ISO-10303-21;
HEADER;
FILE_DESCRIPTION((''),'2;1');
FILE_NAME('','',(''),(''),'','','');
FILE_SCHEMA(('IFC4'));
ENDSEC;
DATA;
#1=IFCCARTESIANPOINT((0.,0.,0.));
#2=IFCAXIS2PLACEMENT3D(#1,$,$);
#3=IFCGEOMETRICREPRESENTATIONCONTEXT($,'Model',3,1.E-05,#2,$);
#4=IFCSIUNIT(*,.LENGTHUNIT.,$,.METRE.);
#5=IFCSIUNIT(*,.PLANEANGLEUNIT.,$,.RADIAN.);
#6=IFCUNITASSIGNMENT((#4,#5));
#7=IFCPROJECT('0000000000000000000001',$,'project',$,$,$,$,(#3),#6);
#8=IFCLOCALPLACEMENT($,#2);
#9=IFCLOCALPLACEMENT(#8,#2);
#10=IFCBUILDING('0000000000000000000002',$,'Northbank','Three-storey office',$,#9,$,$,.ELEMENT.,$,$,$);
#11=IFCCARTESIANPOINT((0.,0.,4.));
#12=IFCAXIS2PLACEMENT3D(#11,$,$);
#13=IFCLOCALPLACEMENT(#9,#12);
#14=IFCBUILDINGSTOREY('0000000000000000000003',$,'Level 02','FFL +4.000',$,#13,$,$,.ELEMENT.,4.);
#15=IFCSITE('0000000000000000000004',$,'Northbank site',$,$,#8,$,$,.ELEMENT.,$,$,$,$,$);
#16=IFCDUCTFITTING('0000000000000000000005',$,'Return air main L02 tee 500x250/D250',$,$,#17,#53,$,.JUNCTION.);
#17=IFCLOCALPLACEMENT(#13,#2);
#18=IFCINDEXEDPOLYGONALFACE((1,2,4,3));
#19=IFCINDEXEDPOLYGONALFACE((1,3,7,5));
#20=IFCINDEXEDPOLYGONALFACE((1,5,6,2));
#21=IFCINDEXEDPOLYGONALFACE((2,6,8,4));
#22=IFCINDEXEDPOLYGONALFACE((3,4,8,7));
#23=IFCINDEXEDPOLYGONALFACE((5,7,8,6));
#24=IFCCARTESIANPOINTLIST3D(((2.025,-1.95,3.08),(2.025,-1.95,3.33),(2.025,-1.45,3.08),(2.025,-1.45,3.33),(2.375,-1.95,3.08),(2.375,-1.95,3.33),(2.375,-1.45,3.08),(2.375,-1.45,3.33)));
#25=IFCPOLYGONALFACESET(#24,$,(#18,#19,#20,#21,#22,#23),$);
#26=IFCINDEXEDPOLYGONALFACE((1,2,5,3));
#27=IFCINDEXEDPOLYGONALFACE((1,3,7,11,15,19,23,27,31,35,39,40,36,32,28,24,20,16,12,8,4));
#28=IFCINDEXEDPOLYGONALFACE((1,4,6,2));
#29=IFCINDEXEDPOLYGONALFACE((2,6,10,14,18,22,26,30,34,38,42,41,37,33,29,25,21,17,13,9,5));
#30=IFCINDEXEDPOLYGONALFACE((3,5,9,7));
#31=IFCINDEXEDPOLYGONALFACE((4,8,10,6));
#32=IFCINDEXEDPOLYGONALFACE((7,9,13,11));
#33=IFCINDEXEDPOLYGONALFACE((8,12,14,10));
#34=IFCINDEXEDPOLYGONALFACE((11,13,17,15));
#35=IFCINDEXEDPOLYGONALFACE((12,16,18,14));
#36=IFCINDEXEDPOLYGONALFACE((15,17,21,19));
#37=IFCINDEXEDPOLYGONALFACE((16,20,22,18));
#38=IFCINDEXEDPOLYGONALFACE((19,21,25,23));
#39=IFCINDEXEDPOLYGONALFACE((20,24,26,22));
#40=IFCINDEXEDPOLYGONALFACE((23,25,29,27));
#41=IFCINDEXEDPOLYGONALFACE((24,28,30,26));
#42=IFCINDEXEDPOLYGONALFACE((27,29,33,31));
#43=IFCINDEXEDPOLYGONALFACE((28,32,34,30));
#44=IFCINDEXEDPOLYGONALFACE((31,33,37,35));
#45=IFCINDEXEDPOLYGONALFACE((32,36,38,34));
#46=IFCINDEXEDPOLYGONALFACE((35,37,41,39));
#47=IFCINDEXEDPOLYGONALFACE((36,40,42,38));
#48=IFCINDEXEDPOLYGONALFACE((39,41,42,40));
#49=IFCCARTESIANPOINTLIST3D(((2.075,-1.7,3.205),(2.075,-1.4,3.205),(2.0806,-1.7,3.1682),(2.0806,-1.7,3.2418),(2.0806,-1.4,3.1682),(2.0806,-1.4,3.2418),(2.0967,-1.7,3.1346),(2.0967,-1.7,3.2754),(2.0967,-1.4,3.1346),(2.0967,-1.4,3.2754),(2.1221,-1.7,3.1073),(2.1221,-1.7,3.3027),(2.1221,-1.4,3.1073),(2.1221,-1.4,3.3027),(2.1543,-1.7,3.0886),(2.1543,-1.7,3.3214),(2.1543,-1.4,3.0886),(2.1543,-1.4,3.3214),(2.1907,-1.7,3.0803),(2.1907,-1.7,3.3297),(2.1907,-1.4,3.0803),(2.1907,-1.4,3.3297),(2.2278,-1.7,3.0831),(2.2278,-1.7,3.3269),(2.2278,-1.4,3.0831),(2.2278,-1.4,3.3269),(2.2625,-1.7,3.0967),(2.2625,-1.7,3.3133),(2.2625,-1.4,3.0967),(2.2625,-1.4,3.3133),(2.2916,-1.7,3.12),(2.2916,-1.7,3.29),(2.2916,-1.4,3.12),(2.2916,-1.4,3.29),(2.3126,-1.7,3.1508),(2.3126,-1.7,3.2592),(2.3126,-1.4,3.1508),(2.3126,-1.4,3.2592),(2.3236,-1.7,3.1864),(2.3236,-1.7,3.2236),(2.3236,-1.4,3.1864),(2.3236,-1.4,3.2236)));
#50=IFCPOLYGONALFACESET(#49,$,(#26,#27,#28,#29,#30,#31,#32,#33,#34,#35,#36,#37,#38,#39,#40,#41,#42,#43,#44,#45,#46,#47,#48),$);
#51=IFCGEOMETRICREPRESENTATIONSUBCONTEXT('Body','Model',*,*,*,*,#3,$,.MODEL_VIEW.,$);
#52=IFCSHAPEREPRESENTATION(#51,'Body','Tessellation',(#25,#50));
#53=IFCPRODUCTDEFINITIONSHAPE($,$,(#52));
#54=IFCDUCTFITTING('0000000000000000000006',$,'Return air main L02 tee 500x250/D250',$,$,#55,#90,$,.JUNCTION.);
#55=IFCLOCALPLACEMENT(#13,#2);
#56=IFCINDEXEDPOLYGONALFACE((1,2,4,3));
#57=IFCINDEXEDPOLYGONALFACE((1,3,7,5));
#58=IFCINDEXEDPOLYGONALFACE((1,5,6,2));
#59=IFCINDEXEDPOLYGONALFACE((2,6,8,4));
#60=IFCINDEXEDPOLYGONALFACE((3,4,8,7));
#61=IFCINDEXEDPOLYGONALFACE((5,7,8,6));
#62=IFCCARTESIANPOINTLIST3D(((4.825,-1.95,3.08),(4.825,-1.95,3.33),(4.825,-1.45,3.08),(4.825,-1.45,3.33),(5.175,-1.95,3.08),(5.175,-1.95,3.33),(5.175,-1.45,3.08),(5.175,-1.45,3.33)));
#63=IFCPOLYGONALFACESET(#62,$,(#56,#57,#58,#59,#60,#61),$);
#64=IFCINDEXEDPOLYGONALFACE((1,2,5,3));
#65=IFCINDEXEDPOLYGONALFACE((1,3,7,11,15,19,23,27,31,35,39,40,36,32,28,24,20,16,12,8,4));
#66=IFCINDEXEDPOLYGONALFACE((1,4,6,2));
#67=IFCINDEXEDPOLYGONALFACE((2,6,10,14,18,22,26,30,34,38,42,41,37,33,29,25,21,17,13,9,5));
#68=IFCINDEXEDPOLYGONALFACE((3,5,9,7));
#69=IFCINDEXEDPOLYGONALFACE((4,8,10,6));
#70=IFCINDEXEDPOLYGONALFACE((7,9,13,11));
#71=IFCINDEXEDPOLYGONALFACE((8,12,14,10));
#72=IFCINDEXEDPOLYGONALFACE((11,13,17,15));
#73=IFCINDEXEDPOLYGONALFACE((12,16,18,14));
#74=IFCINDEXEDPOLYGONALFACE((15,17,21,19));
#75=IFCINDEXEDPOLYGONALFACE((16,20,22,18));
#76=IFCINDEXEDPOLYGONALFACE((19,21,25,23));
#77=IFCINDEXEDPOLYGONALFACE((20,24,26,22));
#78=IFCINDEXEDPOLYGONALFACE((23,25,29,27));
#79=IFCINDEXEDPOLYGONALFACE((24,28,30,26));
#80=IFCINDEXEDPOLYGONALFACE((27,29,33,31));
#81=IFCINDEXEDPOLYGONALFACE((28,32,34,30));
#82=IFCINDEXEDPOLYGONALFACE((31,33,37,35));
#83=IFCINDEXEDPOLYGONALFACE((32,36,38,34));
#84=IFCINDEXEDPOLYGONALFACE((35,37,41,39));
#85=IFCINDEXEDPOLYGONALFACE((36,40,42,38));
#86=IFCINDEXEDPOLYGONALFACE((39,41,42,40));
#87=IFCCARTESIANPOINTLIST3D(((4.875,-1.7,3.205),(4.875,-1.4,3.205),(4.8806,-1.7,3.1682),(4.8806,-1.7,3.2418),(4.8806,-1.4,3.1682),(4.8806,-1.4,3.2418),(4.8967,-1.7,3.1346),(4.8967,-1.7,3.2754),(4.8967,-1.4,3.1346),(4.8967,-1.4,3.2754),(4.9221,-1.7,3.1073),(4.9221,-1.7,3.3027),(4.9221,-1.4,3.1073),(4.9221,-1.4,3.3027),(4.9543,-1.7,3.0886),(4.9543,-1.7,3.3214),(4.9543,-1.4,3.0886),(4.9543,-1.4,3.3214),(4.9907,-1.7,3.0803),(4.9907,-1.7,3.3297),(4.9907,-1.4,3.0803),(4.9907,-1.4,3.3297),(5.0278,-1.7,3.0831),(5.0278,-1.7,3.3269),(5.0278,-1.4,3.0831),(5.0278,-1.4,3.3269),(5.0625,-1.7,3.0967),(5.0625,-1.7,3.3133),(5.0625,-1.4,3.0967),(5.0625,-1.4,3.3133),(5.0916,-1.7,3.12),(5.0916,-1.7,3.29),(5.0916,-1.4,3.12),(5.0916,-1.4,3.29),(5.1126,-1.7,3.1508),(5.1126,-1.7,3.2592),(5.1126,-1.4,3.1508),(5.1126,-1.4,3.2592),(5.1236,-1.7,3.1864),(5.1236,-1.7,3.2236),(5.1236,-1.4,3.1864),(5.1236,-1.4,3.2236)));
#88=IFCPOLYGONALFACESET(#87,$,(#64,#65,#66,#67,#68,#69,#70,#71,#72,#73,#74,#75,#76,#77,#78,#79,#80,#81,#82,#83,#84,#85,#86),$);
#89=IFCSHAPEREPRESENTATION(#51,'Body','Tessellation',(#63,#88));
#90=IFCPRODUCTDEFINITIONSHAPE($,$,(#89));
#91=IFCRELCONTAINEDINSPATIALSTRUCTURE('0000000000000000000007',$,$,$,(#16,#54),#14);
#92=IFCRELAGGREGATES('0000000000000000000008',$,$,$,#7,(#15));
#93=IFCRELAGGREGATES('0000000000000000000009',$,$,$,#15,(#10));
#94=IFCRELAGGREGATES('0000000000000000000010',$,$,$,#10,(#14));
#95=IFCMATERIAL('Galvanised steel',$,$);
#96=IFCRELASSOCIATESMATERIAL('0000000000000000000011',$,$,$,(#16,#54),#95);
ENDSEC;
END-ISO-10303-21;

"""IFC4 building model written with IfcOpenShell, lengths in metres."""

from ifc_helpers import new_model, si_unit, frame, origin, place, context, subcontext, project, spatial, rectangle, circle, extrude, material, element, save


model = new_model("IFC4")

# Units and contexts
model_context = context("Model", 3, precision=1e-05, world=origin())
body_context = subcontext(model_context, "Body", "Model", "MODEL_VIEW")
ifc_project = project(units=[si_unit("LENGTHUNIT", "METRE"), si_unit("PLANEANGLEUNIT", "RADIAN")], contexts=[model_context])

# Site, building, storey
site_placement = place(None, origin())
site = spatial("IfcSite", under=ifc_project, at=site_placement, Name="Northbank site", CompositionType="ELEMENT")
building_placement = place(site_placement, origin())
building = spatial("IfcBuilding", under=site, at=building_placement, Name="Northbank", Description="Three-storey office", CompositionType="ELEMENT")
storey_placement = place(building_placement, frame((0.0, 0.0, 4.0)))
storey = spatial("IfcBuildingStorey", under=building, at=storey_placement, Name="Level 02", Description="FFL +4.000", CompositionType="ELEMENT", Elevation=4.0)

# Shared definitions
ifc_material_1 = material(Name="Galvanised steel")

# Duct fitting
duct_fitting_1_placement = place(storey_placement, frame((0.0, 0.0, -4.0)))
element("IfcDuctFitting", 1, at=duct_fitting_1_placement, inside=storey, material=ifc_material_1, Name="Return air main L02 tee 500x250/D250", PredefinedType="JUNCTION", context=body_context, shape_type="SweptSolid", body=[
    extrude(rectangle(XDim=0.5, YDim=0.25), frame((2.025, -1.7, 7.205), z_axis=(1.0, 0.0, 0.0), x_axis=(0.0, 1.0, 0.0)), (0.0, 0.0, 1.0), 0.35),
    extrude(circle(Radius=0.125), frame((2.2, -1.7, 7.205), z_axis=(0.0, 1.0, 0.0), x_axis=(-1.0, 0.0, 0.0)), (0.0, 0.0, 1.0), 0.3),
])

# Duct fitting
duct_fitting_2_placement = place(storey_placement, frame((0.0, 0.0, -4.0)))
element("IfcDuctFitting", 2, at=duct_fitting_2_placement, inside=storey, material=ifc_material_1, Name="Return air main L02 tee 500x250/D250", PredefinedType="JUNCTION", context=body_context, shape_type="SweptSolid", body=[
    extrude(rectangle(XDim=0.5, YDim=0.25), frame((4.825, -1.7, 7.205), z_axis=(1.0, 0.0, 0.0), x_axis=(0.0, 1.0, 0.0)), (0.0, 0.0, 1.0), 0.35),
    extrude(circle(Radius=0.125), frame((5.0, -1.7, 7.205), z_axis=(0.0, 1.0, 0.0), x_axis=(-1.0, 0.0, 0.0)), (0.0, 0.0, 1.0), 0.3),
])

save(model, "model.ifc")
